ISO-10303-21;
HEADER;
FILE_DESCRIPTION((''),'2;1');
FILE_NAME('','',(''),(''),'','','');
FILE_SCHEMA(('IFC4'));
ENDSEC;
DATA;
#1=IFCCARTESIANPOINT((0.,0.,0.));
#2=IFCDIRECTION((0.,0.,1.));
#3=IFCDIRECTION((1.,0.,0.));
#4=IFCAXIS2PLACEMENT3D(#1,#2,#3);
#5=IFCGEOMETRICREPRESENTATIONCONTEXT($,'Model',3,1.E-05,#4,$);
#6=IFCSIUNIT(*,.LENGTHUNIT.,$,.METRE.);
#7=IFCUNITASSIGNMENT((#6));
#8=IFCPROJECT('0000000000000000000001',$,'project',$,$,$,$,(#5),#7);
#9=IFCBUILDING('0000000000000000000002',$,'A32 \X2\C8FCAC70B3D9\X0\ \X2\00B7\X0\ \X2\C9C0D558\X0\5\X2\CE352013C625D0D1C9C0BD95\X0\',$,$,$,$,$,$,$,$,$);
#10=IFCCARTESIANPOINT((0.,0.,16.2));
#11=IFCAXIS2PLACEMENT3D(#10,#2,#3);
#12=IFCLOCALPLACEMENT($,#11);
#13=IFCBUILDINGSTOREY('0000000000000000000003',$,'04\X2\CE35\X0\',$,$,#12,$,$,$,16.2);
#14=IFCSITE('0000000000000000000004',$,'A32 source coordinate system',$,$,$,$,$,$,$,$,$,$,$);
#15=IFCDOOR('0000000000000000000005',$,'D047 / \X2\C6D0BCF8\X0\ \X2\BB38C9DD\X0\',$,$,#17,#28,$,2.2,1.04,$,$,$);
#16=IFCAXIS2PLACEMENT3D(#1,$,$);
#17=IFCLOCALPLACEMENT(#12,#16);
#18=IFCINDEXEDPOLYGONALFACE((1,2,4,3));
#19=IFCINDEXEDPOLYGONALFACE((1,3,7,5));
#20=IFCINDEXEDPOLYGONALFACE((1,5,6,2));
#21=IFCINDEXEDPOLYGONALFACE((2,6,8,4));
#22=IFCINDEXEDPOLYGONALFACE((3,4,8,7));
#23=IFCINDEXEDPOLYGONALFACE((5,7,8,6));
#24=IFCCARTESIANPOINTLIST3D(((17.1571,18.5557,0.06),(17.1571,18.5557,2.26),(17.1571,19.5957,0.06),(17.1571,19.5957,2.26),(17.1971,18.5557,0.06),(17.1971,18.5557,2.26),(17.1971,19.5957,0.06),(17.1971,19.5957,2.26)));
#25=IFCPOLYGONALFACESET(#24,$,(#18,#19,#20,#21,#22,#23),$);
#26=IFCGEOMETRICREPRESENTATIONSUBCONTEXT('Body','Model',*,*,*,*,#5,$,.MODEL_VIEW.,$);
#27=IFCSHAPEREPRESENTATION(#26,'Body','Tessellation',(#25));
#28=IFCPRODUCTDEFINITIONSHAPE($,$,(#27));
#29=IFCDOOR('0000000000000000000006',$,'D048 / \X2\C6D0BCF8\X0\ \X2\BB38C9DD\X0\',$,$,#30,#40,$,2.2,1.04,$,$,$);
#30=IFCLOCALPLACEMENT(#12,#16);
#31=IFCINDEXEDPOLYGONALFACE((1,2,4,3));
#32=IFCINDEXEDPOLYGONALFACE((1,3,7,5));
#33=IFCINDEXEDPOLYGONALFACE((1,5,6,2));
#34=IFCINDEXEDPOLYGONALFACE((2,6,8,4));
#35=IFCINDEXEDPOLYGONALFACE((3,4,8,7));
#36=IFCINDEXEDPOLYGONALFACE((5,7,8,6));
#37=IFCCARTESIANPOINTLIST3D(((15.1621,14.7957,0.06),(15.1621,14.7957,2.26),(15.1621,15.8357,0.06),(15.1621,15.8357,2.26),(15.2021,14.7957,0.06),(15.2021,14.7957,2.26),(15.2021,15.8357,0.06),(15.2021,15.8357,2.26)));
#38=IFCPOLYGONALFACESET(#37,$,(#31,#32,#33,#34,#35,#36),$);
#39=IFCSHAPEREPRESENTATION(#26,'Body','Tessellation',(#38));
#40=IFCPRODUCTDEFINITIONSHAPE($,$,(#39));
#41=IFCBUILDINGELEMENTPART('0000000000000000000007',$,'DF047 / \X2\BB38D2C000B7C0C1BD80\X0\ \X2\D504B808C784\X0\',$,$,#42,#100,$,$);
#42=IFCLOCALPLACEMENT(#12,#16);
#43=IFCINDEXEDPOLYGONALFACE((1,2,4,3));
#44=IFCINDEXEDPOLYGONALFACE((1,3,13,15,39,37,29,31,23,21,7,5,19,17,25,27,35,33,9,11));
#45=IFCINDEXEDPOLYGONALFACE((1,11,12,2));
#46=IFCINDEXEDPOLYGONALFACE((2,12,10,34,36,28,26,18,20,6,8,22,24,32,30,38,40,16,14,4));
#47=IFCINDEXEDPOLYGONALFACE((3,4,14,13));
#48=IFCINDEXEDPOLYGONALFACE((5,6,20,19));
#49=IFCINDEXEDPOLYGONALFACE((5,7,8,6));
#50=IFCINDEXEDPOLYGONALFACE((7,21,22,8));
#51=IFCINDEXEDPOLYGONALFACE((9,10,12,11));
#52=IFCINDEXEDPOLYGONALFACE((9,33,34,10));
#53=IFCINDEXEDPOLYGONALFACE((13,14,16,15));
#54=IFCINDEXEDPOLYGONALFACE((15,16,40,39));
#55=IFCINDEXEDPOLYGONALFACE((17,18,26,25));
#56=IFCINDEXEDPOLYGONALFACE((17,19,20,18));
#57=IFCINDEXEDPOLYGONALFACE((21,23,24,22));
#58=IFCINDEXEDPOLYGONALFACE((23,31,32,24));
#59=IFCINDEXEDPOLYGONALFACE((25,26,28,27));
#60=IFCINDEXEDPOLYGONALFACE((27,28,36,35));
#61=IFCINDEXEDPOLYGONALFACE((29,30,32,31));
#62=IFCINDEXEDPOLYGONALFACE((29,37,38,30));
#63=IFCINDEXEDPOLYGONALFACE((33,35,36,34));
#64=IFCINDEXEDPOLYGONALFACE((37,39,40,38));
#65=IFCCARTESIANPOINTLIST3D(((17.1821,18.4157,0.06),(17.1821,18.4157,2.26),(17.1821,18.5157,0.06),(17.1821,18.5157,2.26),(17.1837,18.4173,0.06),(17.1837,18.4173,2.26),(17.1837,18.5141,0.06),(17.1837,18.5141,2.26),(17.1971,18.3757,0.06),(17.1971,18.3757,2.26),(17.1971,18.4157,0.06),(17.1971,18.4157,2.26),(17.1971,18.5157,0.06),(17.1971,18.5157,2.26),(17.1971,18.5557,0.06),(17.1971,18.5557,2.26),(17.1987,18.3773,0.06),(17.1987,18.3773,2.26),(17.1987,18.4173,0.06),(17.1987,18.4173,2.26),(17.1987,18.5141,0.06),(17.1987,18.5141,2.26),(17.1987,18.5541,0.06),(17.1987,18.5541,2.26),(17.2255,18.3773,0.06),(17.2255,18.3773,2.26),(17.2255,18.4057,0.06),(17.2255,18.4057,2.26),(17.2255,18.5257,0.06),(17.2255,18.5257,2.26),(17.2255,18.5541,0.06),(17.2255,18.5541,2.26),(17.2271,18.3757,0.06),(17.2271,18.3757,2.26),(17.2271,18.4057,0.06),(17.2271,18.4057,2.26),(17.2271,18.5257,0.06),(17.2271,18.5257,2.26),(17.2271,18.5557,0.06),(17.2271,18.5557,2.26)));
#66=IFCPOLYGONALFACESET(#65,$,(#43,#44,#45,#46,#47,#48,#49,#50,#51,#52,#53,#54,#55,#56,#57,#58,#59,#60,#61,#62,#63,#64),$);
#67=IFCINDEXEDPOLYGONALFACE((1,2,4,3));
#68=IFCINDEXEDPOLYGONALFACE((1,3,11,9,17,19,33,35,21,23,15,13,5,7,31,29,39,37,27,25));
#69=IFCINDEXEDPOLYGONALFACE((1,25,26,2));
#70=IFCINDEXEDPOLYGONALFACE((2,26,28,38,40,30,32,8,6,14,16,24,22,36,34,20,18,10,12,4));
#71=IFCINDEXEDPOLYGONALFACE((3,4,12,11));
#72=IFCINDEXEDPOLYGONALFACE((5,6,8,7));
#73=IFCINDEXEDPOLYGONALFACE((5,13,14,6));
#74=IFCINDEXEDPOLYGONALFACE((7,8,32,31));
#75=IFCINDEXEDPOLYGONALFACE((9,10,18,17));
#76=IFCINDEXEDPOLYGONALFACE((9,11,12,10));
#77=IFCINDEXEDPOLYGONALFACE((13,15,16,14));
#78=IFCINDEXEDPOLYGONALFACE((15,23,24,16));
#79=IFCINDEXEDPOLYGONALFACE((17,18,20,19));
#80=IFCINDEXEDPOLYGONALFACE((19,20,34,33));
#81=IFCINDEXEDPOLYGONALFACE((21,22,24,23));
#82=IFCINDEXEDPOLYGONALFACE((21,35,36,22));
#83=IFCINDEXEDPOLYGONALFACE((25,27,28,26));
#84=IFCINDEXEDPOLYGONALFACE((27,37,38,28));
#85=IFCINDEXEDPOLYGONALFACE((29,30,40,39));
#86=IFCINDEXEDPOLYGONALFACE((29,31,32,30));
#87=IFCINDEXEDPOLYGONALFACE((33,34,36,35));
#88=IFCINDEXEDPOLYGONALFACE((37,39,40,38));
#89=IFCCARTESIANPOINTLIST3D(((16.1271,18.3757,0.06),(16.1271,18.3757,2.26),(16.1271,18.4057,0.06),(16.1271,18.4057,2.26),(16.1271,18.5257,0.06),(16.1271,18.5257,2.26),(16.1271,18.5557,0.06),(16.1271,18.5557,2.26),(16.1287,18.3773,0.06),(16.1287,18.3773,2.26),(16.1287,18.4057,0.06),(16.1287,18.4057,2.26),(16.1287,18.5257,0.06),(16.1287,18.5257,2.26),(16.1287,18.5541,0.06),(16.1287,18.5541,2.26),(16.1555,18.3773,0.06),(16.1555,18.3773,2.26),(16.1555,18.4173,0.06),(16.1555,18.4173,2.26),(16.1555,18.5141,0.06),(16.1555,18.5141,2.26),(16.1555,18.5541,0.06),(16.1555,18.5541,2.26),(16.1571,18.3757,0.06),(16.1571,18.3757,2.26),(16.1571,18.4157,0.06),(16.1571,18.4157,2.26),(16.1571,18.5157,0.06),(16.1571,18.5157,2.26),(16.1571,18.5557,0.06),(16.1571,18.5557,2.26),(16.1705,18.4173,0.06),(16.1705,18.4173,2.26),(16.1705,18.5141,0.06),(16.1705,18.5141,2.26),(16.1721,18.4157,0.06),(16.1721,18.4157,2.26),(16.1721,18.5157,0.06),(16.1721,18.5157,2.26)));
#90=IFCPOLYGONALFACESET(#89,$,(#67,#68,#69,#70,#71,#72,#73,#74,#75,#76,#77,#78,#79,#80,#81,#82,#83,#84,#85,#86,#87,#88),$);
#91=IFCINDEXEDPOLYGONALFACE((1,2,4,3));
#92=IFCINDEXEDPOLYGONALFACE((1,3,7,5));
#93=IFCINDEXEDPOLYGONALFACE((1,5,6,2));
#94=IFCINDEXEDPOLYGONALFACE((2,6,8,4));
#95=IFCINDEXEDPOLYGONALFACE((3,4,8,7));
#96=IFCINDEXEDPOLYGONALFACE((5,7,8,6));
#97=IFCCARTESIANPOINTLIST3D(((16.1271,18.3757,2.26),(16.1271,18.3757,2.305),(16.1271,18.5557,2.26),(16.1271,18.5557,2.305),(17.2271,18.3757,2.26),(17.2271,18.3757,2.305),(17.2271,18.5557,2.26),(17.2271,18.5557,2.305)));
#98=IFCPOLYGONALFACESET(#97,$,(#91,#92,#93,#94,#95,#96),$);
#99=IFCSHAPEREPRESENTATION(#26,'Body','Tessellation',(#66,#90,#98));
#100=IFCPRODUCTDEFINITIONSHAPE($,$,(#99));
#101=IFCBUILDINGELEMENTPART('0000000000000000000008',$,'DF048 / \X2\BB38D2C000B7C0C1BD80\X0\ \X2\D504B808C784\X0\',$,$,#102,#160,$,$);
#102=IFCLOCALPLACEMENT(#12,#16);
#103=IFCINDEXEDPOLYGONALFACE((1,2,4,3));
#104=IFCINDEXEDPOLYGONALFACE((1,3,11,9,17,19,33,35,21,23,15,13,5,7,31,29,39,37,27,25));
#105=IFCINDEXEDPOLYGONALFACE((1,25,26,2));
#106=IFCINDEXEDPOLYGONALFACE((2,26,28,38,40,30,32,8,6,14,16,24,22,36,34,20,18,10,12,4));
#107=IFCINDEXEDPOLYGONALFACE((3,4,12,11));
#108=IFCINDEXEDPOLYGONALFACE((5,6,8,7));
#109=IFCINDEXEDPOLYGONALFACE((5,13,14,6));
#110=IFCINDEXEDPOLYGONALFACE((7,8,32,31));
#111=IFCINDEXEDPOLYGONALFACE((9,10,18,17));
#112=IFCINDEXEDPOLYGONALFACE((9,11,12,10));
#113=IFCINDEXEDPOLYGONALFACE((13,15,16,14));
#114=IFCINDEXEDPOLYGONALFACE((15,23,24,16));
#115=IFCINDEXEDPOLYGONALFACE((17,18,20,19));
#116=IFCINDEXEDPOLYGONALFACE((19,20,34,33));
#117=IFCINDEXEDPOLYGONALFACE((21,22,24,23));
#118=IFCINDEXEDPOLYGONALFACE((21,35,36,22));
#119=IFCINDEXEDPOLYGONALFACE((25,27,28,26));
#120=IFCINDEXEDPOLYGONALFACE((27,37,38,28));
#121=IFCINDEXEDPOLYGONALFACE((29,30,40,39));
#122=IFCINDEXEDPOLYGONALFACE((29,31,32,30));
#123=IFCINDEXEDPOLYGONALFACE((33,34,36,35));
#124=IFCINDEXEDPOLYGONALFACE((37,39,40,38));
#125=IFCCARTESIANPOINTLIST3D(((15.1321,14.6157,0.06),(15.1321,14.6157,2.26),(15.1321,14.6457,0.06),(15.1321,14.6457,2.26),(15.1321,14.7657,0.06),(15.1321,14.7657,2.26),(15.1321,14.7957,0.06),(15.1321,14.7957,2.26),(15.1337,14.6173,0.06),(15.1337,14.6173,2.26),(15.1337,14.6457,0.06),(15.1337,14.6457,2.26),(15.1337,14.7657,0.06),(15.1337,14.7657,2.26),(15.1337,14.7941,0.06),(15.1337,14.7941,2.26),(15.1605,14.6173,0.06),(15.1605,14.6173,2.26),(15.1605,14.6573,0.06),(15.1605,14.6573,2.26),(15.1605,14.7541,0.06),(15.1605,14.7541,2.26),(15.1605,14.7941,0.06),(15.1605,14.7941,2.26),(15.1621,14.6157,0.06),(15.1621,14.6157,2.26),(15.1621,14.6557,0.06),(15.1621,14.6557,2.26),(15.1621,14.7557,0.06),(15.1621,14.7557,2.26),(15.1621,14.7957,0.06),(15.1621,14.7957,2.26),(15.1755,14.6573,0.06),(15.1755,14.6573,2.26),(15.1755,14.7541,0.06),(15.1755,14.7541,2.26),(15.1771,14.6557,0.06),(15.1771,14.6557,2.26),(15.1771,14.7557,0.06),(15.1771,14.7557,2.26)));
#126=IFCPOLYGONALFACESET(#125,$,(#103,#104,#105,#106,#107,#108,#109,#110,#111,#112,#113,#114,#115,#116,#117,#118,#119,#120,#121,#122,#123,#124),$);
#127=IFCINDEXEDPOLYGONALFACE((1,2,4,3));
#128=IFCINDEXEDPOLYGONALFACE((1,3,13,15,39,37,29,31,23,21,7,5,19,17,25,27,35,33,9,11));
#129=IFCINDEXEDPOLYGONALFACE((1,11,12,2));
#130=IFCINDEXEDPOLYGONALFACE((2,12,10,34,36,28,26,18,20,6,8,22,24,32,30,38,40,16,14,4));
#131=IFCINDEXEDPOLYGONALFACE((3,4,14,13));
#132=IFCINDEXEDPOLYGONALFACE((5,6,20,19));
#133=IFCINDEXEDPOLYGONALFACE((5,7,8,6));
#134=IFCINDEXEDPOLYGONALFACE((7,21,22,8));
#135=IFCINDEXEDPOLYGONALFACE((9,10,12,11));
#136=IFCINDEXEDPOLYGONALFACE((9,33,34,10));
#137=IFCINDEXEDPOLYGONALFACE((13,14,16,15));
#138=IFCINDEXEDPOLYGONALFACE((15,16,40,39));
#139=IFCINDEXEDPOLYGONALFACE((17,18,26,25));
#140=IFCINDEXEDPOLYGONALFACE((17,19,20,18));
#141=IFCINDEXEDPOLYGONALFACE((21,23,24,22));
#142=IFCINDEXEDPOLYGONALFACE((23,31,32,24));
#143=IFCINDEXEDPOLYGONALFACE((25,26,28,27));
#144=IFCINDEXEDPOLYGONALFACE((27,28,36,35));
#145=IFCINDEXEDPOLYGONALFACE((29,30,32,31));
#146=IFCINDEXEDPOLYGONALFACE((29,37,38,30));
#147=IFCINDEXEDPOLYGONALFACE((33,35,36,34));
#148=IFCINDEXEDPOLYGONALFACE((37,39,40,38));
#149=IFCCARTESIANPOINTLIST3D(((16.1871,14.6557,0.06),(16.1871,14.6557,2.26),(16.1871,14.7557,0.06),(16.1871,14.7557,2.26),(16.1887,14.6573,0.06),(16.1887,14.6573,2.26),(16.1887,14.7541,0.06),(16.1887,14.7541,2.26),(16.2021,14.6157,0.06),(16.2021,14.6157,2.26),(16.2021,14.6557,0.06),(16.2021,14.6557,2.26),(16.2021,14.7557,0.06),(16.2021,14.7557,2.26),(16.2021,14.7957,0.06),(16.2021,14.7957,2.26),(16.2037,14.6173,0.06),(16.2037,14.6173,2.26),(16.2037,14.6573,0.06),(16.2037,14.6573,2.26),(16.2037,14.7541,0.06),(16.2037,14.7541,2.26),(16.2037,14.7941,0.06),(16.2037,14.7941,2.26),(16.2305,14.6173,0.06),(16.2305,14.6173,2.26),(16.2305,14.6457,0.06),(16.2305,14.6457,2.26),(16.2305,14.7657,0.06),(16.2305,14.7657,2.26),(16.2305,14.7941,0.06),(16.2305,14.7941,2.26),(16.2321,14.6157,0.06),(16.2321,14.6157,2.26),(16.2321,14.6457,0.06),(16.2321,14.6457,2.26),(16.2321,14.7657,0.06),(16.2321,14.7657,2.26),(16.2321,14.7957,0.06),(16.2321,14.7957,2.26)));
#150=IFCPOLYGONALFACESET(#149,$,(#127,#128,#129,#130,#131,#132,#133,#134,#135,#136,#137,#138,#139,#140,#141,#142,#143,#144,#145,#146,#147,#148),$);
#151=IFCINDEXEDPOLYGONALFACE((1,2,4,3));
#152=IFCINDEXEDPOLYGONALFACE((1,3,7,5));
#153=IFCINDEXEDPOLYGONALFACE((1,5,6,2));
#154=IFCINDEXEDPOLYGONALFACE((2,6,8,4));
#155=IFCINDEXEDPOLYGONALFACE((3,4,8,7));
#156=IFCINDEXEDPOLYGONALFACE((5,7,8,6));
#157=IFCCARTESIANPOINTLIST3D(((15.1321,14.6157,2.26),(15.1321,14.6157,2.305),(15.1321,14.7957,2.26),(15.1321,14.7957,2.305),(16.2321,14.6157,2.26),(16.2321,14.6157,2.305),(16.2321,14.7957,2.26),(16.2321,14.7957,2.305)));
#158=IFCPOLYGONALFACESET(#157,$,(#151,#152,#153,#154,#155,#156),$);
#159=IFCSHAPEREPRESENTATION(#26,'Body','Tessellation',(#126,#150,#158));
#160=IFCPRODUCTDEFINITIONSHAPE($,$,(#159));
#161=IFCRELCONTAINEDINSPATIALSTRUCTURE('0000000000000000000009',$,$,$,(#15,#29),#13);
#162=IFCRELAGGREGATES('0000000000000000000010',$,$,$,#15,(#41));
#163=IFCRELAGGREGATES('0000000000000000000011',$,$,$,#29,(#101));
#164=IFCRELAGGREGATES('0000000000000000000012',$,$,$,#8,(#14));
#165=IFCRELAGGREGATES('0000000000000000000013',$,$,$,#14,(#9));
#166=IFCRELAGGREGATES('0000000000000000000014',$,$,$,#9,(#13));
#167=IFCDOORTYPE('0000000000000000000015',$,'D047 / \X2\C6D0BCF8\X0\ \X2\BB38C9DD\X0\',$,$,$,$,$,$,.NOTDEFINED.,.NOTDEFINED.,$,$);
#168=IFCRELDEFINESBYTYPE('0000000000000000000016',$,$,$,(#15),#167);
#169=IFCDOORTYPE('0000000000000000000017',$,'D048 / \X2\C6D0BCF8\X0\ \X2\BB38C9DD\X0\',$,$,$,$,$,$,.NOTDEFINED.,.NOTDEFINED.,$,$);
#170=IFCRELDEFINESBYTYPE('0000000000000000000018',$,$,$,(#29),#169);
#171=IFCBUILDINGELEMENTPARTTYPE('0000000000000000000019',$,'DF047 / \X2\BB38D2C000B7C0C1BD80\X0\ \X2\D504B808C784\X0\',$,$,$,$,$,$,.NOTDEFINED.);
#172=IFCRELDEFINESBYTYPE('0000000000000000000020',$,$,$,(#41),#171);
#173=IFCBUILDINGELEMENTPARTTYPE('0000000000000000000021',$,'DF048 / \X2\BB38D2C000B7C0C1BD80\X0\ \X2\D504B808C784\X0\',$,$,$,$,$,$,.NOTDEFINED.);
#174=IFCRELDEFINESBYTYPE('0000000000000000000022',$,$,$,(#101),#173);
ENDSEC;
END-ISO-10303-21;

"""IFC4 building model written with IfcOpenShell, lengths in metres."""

from ifc_helpers import new_model, si_unit, frame, origin, origin_with_axes, place, context, subcontext, project, spatial, polyline, outline, extrude, source, transform, mapped, type_object, type_shapes, element, aggregate, save


model = new_model("IFC4")

# Units and contexts
model_context = context("Model", 3, precision=1e-05, world=origin_with_axes())
body_context = subcontext(model_context, "Body", "Model", "MODEL_VIEW")
ifc_project = project(units=[si_unit("LENGTHUNIT", "METRE")], contexts=[model_context])

# Site, building, storey
storey_placement = place(None, frame((0.0, 0.0, 16.2), z_axis=(0.0, 0.0, 1.0), x_axis=(1.0, 0.0, 0.0)))
site = spatial("IfcSite", under=ifc_project, Name="A32 source coordinate system")
building = spatial("IfcBuilding", under=site, Name="A32 주거동 · 지하5층–옥탑지붕")
storey = spatial("IfcBuildingStorey", under=building, at=storey_placement, Name="04층", Elevation=16.2)

# Doors
door_type_1 = type_object("IfcDoorType", Name="D047 / 원본 문짝", OperationType="NOTDEFINED", PredefinedType="NOTDEFINED")
shared_shape_1 = source(origin(), body_context, "Body", "SweptSolid", [
    extrude(outline(polyline([(17.1971, 18.5557), (17.1571, 18.5557), (17.1571, 19.5957), (17.1971, 19.5957), (17.1971, 18.5557)])), frame((0.0, 0.0, 0.06)), (0.0, 0.0, 1.0), 2.2),
])
type_shapes(door_type_1, [shared_shape_1])
door_1_placement = place(storey_placement, origin_with_axes())
door_1 = element("IfcDoor", 1, at=door_1_placement, inside=storey, type_object=door_type_1, Name="D047 / 원본 문짝", OverallHeight=2.2, OverallWidth=1.04, context=body_context, shape_type="MappedRepresentation", body=[
    mapped(shared_shape_1, transform((0.0, 0.0, 0.0), scale=1.0)),
])
door_type_2 = type_object("IfcDoorType", Name="D048 / 원본 문짝", OperationType="NOTDEFINED", PredefinedType="NOTDEFINED")
shared_shape_2 = source(origin(), body_context, "Body", "SweptSolid", [
    extrude(outline(polyline([(15.2021, 15.8357), (15.2021, 14.7957), (15.1621, 14.7957), (15.1621, 15.8357), (15.2021, 15.8357)])), frame((0.0, 0.0, 0.06)), (0.0, 0.0, 1.0), 2.2),
])
type_shapes(door_type_2, [shared_shape_2])
door_2_placement = place(storey_placement, origin_with_axes())
door_2 = element("IfcDoor", 2, at=door_2_placement, inside=storey, type_object=door_type_2, Name="D048 / 원본 문짝", OverallHeight=2.2, OverallWidth=1.04, context=body_context, shape_type="MappedRepresentation", body=[
    mapped(shared_shape_2, transform((0.0, 0.0, 0.0), scale=1.0)),
])

# Building element parts
building_element_part_type_1 = type_object("IfcBuildingElementPartType", Name="DF047 / 문틀·상부 프레임", PredefinedType="NOTDEFINED")
shared_shape_3 = source(origin(), body_context, "Body", "SweptSolid", [
    extrude(outline(polyline([(17.2255, 18.5541), (17.1987, 18.5541), (17.1987, 18.5141), (17.1837, 18.5141), (17.1837, 18.4173), (17.1987, 18.4173), (17.1987, 18.3773), (17.2255, 18.3773), (17.2255, 18.4057), (17.2271, 18.4057), (17.2271, 18.3757), (17.1971, 18.3757), (17.1971, 18.4157), (17.1821, 18.4157), (17.1821, 18.5157), (17.1971, 18.5157), (17.1971, 18.5557), (17.2271, 18.5557), (17.2271, 18.5257), (17.2255, 18.5257), (17.2255, 18.5541)])), frame((0.0, 0.0, 0.06)), (0.0, 0.0, 1.0), 2.2),
    extrude(outline(polyline([(16.1271, 18.5257), (16.1271, 18.5557), (16.1571, 18.5557), (16.1571, 18.5157), (16.1721, 18.5157), (16.1721, 18.4157), (16.1571, 18.4157), (16.1571, 18.3757), (16.1271, 18.3757), (16.1271, 18.4057), (16.1287, 18.4057), (16.1287, 18.3773), (16.1555, 18.3773), (16.1555, 18.4173), (16.1705, 18.4173), (16.1705, 18.5141), (16.1555, 18.5141), (16.1555, 18.5541), (16.1287, 18.5541), (16.1287, 18.5257), (16.1271, 18.5257)])), frame((0.0, 0.0, 0.06)), (0.0, 0.0, 1.0), 2.2),
    extrude(outline(polyline([(16.1271, 18.3757), (16.1271, 18.5557), (17.2271, 18.5557), (17.2271, 18.3757), (16.1271, 18.3757)])), frame((0.0, 0.0, 2.26)), (0.0, 0.0, 1.0), 0.045),
])
type_shapes(building_element_part_type_1, [shared_shape_3])
building_element_part_1_placement = place(door_1_placement, origin_with_axes())
building_element_part_1 = element("IfcBuildingElementPart", 3, at=building_element_part_1_placement, type_object=building_element_part_type_1, Name="DF047 / 문틀·상부 프레임", context=body_context, shape_type="MappedRepresentation", body=[
    mapped(shared_shape_3, transform((0.0, 0.0, 0.0), scale=1.0)),
])
aggregate(door_1, [building_element_part_1])
building_element_part_type_2 = type_object("IfcBuildingElementPartType", Name="DF048 / 문틀·상부 프레임", PredefinedType="NOTDEFINED")
shared_shape_4 = source(origin(), body_context, "Body", "SweptSolid", [
    extrude(outline(polyline([(15.1321, 14.7657), (15.1321, 14.7957), (15.1621, 14.7957), (15.1621, 14.7557), (15.1771, 14.7557), (15.1771, 14.6557), (15.1621, 14.6557), (15.1621, 14.6157), (15.1321, 14.6157), (15.1321, 14.6457), (15.1337, 14.6457), (15.1337, 14.6173), (15.1605, 14.6173), (15.1605, 14.6573), (15.1755, 14.6573), (15.1755, 14.7541), (15.1605, 14.7541), (15.1605, 14.7941), (15.1337, 14.7941), (15.1337, 14.7657), (15.1321, 14.7657)])), frame((0.0, 0.0, 0.06)), (0.0, 0.0, 1.0), 2.2),
    extrude(outline(polyline([(16.2305, 14.7941), (16.2037, 14.7941), (16.2037, 14.7541), (16.1887, 14.7541), (16.1887, 14.6573), (16.2037, 14.6573), (16.2037, 14.6173), (16.2305, 14.6173), (16.2305, 14.6457), (16.2321, 14.6457), (16.2321, 14.6157), (16.2021, 14.6157), (16.2021, 14.6557), (16.1871, 14.6557), (16.1871, 14.7557), (16.2021, 14.7557), (16.2021, 14.7957), (16.2321, 14.7957), (16.2321, 14.7657), (16.2305, 14.7657), (16.2305, 14.7941)])), frame((0.0, 0.0, 0.06)), (0.0, 0.0, 1.0), 2.2),
    extrude(outline(polyline([(15.1321, 14.6157), (15.1321, 14.7957), (16.2321, 14.7957), (16.2321, 14.6157), (15.1321, 14.6157)])), frame((0.0, 0.0, 2.26)), (0.0, 0.0, 1.0), 0.045),
])
type_shapes(building_element_part_type_2, [shared_shape_4])
building_element_part_2_placement = place(door_2_placement, origin_with_axes())
building_element_part_2 = element("IfcBuildingElementPart", 4, at=building_element_part_2_placement, type_object=building_element_part_type_2, Name="DF048 / 문틀·상부 프레임", context=body_context, shape_type="MappedRepresentation", body=[
    mapped(shared_shape_4, transform((0.0, 0.0, 0.0), scale=1.0)),
])
aggregate(door_2, [building_element_part_2])

save(model, "model.ifc")
